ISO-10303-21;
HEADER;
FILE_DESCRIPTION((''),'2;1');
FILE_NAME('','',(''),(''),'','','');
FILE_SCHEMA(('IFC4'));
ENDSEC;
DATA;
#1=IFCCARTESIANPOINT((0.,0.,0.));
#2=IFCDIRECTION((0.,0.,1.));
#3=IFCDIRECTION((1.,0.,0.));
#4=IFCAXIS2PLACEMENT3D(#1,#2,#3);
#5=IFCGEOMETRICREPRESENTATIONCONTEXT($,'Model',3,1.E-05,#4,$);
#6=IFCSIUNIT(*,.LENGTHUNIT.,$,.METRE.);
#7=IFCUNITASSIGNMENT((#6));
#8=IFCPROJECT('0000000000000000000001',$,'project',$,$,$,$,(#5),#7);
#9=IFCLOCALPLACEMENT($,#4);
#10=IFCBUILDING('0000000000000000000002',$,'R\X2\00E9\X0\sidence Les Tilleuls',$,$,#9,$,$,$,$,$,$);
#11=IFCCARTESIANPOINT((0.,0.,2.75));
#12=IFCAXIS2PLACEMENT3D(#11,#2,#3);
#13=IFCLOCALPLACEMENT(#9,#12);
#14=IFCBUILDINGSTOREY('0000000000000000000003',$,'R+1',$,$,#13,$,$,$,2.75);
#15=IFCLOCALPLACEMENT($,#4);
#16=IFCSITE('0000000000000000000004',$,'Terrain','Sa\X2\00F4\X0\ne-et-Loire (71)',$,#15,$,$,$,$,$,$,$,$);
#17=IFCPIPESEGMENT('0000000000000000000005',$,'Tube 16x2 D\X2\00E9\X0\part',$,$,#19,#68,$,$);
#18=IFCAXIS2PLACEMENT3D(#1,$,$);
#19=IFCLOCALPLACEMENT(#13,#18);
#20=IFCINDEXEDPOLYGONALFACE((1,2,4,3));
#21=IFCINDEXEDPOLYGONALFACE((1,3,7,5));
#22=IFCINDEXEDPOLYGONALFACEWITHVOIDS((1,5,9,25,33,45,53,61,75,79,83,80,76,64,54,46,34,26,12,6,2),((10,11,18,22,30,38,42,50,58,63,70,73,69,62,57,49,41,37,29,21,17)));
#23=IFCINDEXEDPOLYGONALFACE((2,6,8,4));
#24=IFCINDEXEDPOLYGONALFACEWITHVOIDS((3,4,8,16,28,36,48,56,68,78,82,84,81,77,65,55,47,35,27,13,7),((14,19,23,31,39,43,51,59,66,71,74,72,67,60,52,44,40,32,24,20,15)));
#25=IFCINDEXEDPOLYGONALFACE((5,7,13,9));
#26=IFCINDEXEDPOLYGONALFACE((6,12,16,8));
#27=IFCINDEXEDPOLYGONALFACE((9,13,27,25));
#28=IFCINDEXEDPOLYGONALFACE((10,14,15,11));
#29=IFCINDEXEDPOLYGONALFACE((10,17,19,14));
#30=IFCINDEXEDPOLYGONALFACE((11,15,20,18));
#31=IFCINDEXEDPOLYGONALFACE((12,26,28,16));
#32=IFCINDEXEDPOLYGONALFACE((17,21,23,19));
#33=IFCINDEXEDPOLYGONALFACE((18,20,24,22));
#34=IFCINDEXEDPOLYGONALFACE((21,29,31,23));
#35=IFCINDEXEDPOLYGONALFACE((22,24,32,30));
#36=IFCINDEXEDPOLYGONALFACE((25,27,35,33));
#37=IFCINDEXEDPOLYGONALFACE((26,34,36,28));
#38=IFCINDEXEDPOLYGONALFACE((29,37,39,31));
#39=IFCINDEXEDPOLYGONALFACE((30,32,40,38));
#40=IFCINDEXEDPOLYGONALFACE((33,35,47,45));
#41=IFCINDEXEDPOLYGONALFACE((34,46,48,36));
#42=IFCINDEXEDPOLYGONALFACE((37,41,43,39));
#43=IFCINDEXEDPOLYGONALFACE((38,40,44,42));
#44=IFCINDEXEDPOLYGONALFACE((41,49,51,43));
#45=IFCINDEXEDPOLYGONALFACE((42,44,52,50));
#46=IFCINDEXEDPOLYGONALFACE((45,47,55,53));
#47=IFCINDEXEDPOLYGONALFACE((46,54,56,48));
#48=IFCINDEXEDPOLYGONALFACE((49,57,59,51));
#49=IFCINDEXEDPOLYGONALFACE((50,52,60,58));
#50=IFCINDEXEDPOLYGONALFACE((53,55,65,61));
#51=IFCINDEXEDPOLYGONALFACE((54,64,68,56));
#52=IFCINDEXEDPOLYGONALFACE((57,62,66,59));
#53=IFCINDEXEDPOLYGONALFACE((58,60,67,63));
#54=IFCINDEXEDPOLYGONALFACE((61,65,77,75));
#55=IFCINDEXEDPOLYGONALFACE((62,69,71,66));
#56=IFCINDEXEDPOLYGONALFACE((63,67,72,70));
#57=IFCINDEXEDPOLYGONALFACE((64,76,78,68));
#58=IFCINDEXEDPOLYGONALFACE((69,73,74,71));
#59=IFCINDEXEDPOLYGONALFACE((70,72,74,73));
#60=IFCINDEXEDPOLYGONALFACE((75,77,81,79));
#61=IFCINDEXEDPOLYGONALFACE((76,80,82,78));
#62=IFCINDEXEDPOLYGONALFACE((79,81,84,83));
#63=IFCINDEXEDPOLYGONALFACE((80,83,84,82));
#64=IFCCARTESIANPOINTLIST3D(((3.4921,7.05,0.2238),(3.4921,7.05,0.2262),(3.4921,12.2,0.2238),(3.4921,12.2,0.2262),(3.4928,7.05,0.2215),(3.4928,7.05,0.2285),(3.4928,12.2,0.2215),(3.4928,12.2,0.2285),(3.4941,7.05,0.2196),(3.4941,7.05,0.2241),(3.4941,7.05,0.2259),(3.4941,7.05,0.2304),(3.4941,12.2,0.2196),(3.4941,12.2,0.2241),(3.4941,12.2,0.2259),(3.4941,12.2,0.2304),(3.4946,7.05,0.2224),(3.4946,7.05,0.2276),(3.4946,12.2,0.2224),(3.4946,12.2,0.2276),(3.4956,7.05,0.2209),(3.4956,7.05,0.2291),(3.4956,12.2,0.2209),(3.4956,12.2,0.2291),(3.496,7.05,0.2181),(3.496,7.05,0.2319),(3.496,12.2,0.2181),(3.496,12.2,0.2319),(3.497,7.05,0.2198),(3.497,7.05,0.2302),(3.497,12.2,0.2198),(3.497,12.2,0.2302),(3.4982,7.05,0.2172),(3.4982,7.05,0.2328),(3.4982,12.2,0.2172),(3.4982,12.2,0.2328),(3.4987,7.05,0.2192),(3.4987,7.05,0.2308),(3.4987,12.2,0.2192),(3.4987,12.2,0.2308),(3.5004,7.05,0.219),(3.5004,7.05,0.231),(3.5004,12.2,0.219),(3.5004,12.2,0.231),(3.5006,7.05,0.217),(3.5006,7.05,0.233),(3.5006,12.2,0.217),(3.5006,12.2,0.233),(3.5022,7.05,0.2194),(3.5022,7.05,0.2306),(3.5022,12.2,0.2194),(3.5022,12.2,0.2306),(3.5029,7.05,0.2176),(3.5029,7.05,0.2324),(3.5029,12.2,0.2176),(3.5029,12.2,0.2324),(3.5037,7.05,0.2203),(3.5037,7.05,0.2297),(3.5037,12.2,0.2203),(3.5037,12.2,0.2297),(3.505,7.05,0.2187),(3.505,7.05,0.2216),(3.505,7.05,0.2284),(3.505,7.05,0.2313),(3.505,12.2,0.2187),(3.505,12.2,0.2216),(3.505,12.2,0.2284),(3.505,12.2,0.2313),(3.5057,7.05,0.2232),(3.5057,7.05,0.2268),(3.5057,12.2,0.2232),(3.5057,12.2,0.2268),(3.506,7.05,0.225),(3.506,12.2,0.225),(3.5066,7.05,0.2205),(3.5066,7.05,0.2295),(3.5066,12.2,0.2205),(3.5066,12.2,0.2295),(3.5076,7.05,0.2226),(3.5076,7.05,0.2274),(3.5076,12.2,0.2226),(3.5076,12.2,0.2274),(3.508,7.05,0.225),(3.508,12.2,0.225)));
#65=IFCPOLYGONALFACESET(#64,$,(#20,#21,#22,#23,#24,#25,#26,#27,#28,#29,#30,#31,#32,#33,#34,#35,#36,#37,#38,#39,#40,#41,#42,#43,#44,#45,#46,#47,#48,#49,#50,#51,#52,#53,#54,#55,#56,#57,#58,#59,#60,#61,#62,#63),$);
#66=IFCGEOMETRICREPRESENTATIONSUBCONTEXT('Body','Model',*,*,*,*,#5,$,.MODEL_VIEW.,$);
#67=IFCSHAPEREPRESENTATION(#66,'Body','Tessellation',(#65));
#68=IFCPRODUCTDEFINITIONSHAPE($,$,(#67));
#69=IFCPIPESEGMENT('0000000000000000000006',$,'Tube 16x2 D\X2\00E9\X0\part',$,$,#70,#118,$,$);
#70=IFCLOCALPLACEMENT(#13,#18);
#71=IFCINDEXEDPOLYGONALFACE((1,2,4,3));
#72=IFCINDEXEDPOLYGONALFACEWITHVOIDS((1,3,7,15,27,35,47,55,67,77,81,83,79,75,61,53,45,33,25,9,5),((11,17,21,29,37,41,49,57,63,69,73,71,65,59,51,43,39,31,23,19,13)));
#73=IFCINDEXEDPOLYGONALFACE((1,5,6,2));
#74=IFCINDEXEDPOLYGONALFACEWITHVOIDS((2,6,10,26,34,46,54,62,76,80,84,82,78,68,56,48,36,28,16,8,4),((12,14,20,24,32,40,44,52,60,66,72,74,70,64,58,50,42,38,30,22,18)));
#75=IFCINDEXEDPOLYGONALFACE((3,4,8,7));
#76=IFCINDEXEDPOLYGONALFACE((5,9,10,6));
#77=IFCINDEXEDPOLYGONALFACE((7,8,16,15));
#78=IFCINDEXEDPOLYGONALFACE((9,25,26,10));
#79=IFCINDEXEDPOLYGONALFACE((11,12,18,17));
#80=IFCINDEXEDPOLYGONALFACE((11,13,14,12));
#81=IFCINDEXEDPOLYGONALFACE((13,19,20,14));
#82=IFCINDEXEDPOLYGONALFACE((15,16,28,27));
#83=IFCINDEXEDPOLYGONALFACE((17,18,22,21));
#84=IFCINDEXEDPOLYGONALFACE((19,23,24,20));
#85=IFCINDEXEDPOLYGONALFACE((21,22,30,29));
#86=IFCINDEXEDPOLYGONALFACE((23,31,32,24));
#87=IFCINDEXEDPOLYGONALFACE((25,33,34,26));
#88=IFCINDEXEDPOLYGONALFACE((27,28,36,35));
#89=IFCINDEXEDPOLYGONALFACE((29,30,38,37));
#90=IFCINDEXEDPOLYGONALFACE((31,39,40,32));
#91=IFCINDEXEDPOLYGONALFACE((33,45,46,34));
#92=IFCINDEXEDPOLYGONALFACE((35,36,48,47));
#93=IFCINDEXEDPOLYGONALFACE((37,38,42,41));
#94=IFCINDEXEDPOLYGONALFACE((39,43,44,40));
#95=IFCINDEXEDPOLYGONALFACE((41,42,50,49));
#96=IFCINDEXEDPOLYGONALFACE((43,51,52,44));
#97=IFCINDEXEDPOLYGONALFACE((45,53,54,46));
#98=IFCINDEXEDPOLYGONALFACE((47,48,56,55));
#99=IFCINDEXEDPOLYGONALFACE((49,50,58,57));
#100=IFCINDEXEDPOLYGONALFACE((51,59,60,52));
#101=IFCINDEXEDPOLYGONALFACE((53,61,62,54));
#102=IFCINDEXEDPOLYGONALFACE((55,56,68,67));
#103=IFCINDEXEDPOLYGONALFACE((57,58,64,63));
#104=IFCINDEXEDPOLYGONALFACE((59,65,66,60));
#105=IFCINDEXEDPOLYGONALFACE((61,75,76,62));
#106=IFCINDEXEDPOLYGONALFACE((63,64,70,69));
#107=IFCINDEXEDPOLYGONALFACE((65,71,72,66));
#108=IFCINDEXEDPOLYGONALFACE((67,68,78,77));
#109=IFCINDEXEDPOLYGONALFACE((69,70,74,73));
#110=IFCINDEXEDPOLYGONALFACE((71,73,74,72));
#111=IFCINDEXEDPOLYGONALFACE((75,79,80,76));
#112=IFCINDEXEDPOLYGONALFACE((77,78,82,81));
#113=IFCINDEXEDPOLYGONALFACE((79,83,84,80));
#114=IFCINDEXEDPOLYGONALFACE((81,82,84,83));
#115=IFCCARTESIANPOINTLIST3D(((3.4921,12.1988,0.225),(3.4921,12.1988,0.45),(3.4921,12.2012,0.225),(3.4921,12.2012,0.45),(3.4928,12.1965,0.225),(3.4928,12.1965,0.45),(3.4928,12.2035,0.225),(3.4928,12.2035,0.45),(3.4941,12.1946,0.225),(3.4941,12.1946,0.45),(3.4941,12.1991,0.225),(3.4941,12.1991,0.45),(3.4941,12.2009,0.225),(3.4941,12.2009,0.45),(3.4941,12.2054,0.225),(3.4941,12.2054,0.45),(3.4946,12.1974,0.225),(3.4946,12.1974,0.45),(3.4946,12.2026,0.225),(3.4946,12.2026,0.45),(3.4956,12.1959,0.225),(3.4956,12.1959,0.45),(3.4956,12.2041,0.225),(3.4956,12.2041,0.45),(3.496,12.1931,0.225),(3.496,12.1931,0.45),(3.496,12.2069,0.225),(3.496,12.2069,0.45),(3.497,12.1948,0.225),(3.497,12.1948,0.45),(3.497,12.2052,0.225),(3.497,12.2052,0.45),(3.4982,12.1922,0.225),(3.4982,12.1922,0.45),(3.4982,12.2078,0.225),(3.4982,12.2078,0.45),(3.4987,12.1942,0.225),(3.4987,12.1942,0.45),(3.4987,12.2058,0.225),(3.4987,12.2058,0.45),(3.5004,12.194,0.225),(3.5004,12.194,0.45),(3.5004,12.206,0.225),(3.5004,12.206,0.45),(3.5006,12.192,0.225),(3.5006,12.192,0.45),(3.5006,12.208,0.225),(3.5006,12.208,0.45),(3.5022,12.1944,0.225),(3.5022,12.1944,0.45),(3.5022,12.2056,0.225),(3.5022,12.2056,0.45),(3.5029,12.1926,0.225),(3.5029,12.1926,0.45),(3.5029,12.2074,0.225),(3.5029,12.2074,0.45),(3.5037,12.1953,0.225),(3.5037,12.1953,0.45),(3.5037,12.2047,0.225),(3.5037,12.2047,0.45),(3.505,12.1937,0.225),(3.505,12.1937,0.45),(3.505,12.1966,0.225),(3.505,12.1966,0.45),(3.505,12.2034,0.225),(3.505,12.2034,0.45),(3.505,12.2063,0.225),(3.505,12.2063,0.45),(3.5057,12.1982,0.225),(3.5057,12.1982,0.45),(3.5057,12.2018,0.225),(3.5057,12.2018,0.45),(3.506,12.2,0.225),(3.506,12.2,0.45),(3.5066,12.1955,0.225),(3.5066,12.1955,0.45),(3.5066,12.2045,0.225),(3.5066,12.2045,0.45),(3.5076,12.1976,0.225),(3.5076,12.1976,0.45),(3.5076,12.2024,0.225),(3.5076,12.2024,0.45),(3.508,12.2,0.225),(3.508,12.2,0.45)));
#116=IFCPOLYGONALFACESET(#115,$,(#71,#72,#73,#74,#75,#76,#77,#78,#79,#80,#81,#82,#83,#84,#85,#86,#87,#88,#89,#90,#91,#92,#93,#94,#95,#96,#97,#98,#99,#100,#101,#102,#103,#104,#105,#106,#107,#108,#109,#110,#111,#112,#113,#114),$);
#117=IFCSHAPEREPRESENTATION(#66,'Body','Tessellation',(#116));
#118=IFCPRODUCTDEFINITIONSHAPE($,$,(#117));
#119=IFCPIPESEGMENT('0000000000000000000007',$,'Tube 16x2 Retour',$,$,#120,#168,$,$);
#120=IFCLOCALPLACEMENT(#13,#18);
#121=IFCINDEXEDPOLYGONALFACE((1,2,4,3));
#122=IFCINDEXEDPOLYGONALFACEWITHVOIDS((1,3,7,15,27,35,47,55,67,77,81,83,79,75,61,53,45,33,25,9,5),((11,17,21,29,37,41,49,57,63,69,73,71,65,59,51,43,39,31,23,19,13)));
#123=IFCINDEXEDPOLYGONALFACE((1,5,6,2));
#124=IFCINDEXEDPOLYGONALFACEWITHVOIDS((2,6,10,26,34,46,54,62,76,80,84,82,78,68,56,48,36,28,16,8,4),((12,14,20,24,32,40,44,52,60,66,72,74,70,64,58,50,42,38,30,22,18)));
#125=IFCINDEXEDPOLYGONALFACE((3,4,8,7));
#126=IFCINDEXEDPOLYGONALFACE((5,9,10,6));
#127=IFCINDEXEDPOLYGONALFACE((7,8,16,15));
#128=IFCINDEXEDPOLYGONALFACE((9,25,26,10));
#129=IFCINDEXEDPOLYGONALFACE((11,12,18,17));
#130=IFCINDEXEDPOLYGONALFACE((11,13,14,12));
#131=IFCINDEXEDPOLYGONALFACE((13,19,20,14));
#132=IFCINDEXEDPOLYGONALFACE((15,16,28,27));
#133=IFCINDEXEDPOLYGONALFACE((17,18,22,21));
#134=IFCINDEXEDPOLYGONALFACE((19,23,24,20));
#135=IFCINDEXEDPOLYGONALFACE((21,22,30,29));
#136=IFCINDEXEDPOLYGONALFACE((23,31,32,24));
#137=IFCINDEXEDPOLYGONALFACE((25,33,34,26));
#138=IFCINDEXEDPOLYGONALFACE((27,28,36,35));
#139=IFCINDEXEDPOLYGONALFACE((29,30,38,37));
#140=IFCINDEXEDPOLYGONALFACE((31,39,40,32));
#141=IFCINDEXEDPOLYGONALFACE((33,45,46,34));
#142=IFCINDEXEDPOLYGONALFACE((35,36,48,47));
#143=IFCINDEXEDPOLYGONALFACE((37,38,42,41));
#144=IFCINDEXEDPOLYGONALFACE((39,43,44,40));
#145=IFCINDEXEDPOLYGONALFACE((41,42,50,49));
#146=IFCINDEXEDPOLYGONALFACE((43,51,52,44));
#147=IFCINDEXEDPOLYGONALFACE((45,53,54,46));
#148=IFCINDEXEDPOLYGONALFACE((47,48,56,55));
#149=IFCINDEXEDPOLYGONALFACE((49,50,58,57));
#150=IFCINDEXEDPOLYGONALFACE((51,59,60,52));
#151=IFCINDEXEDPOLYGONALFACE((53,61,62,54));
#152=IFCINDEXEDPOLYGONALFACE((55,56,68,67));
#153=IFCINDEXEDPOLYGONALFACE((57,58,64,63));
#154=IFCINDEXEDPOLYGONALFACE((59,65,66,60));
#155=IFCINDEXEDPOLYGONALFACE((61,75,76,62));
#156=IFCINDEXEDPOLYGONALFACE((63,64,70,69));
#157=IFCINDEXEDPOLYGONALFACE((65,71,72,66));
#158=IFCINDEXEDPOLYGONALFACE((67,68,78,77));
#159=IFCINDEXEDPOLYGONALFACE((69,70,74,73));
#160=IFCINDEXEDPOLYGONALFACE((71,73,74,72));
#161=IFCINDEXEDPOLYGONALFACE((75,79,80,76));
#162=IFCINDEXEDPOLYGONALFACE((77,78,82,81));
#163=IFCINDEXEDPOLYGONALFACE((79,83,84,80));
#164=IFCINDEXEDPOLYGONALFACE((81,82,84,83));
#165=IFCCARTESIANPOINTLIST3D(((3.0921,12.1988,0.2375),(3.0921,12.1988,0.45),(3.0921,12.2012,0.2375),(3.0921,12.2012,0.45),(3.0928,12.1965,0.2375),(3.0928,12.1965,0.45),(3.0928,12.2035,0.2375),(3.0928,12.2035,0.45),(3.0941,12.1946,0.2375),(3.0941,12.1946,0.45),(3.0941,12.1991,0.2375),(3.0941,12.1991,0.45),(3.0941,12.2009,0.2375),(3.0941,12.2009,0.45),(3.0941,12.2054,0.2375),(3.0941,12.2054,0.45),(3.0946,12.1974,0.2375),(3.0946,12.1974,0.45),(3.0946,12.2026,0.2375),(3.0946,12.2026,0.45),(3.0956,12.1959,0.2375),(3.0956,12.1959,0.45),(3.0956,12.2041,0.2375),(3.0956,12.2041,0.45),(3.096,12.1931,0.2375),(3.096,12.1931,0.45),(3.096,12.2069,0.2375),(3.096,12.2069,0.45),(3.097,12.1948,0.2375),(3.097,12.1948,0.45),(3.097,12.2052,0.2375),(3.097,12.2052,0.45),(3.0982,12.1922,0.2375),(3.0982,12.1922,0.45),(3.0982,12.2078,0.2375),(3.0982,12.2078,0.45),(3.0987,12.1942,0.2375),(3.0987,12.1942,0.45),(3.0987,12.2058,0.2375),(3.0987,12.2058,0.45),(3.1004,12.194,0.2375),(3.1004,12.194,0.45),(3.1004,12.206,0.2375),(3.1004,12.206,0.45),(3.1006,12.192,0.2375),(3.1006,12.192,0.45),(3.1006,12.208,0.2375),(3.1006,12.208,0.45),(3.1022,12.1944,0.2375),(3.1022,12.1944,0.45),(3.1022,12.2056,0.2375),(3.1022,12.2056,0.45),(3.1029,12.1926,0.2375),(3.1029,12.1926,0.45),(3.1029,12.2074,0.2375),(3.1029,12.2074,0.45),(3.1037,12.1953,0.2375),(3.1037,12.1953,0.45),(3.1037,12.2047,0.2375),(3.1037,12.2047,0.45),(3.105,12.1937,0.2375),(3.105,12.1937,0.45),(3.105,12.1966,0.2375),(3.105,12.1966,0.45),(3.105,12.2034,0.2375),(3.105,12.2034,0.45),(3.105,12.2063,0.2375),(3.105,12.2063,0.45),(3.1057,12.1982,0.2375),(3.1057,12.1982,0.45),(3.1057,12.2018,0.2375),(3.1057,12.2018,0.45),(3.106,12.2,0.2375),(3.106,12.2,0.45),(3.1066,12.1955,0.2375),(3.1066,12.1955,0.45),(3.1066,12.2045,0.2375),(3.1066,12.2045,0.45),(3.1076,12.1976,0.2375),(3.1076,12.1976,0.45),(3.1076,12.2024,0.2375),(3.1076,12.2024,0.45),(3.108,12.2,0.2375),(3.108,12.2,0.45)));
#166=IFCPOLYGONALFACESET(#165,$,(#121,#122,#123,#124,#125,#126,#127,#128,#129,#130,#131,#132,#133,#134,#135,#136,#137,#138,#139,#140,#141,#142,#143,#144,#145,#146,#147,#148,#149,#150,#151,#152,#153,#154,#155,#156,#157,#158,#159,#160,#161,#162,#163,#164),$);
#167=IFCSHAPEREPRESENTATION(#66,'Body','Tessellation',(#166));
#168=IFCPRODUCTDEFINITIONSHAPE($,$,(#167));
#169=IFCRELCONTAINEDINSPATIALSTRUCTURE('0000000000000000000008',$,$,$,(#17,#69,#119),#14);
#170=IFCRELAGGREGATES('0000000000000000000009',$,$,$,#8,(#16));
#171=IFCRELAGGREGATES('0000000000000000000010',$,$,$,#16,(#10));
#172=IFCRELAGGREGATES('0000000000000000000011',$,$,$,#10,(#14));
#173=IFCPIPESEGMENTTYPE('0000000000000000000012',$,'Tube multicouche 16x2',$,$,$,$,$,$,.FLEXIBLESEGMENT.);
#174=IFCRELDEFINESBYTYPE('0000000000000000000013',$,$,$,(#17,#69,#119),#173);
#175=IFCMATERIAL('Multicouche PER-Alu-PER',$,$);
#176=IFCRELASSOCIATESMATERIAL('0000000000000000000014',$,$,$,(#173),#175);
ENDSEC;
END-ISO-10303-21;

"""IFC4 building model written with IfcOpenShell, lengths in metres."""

from ifc_helpers import new_model, si_unit, frame, origin_with_axes, place, context, subcontext, project, spatial, hollow_circle, extrude, material, type_object, element, save


model = new_model("IFC4")

# Units and contexts
model_context = context("Model", 3, precision=1e-05, world=origin_with_axes())
body_context = subcontext(model_context, "Body", "Model", "MODEL_VIEW")
ifc_project = project(units=[si_unit("LENGTHUNIT", "METRE")], contexts=[model_context])

# Site, building, storey
site_placement = place(None, origin_with_axes())
site = spatial("IfcSite", under=ifc_project, at=site_placement, Name="Terrain", Description="Saône-et-Loire (71)")
building_placement = place(None, origin_with_axes())
building = spatial("IfcBuilding", under=site, at=building_placement, Name="Résidence Les Tilleuls")
storey_placement = place(building_placement, frame((0.0, 0.0, 2.75), z_axis=(0.0, 0.0, 1.0), x_axis=(1.0, 0.0, 0.0)))
storey = spatial("IfcBuildingStorey", under=building, at=storey_placement, Name="R+1", Elevation=2.75)

# Pipe segments
ifc_material_1 = material(Name="Multicouche PER-Alu-PER")
pipe_segment_type_1 = type_object("IfcPipeSegmentType", Name="Tube multicouche 16x2", PredefinedType="FLEXIBLESEGMENT", material=ifc_material_1)
pipe_segment_1_placement = place(storey_placement, frame((3.5, 7.05, 0.225), z_axis=(0.0, 1.0, 0.0), x_axis=(1.0, 0.0, 0.0)))
element("IfcPipeSegment", 1, at=pipe_segment_1_placement, inside=storey, type_object=pipe_segment_type_1, Name="Tube 16x2 Départ", context=body_context, shape_type="SweptSolid", body=[
    extrude(hollow_circle(Radius=0.008, WallThickness=0.002), origin_with_axes(), (0.0, 0.0, 1.0), 5.15),
])
pipe_segment_2_placement = place(storey_placement, frame((3.5, 12.2, 0.225), z_axis=(0.0, 0.0, 1.0), x_axis=(1.0, 0.0, 0.0)))
element("IfcPipeSegment", 2, at=pipe_segment_2_placement, inside=storey, type_object=pipe_segment_type_1, Name="Tube 16x2 Départ", context=body_context, shape_type="SweptSolid", body=[
    extrude(hollow_circle(Radius=0.008, WallThickness=0.002), origin_with_axes(), (0.0, 0.0, 1.0), 0.225),
])
pipe_segment_3_placement = place(storey_placement, frame((3.1, 12.2, 0.2375), z_axis=(0.0, 0.0, 1.0), x_axis=(1.0, 0.0, 0.0)))
element("IfcPipeSegment", 3, at=pipe_segment_3_placement, inside=storey, type_object=pipe_segment_type_1, Name="Tube 16x2 Retour", context=body_context, shape_type="SweptSolid", body=[
    extrude(hollow_circle(Radius=0.008, WallThickness=0.002), origin_with_axes(), (0.0, 0.0, 1.0), 0.2125),
])

save(model, "model.ifc")
